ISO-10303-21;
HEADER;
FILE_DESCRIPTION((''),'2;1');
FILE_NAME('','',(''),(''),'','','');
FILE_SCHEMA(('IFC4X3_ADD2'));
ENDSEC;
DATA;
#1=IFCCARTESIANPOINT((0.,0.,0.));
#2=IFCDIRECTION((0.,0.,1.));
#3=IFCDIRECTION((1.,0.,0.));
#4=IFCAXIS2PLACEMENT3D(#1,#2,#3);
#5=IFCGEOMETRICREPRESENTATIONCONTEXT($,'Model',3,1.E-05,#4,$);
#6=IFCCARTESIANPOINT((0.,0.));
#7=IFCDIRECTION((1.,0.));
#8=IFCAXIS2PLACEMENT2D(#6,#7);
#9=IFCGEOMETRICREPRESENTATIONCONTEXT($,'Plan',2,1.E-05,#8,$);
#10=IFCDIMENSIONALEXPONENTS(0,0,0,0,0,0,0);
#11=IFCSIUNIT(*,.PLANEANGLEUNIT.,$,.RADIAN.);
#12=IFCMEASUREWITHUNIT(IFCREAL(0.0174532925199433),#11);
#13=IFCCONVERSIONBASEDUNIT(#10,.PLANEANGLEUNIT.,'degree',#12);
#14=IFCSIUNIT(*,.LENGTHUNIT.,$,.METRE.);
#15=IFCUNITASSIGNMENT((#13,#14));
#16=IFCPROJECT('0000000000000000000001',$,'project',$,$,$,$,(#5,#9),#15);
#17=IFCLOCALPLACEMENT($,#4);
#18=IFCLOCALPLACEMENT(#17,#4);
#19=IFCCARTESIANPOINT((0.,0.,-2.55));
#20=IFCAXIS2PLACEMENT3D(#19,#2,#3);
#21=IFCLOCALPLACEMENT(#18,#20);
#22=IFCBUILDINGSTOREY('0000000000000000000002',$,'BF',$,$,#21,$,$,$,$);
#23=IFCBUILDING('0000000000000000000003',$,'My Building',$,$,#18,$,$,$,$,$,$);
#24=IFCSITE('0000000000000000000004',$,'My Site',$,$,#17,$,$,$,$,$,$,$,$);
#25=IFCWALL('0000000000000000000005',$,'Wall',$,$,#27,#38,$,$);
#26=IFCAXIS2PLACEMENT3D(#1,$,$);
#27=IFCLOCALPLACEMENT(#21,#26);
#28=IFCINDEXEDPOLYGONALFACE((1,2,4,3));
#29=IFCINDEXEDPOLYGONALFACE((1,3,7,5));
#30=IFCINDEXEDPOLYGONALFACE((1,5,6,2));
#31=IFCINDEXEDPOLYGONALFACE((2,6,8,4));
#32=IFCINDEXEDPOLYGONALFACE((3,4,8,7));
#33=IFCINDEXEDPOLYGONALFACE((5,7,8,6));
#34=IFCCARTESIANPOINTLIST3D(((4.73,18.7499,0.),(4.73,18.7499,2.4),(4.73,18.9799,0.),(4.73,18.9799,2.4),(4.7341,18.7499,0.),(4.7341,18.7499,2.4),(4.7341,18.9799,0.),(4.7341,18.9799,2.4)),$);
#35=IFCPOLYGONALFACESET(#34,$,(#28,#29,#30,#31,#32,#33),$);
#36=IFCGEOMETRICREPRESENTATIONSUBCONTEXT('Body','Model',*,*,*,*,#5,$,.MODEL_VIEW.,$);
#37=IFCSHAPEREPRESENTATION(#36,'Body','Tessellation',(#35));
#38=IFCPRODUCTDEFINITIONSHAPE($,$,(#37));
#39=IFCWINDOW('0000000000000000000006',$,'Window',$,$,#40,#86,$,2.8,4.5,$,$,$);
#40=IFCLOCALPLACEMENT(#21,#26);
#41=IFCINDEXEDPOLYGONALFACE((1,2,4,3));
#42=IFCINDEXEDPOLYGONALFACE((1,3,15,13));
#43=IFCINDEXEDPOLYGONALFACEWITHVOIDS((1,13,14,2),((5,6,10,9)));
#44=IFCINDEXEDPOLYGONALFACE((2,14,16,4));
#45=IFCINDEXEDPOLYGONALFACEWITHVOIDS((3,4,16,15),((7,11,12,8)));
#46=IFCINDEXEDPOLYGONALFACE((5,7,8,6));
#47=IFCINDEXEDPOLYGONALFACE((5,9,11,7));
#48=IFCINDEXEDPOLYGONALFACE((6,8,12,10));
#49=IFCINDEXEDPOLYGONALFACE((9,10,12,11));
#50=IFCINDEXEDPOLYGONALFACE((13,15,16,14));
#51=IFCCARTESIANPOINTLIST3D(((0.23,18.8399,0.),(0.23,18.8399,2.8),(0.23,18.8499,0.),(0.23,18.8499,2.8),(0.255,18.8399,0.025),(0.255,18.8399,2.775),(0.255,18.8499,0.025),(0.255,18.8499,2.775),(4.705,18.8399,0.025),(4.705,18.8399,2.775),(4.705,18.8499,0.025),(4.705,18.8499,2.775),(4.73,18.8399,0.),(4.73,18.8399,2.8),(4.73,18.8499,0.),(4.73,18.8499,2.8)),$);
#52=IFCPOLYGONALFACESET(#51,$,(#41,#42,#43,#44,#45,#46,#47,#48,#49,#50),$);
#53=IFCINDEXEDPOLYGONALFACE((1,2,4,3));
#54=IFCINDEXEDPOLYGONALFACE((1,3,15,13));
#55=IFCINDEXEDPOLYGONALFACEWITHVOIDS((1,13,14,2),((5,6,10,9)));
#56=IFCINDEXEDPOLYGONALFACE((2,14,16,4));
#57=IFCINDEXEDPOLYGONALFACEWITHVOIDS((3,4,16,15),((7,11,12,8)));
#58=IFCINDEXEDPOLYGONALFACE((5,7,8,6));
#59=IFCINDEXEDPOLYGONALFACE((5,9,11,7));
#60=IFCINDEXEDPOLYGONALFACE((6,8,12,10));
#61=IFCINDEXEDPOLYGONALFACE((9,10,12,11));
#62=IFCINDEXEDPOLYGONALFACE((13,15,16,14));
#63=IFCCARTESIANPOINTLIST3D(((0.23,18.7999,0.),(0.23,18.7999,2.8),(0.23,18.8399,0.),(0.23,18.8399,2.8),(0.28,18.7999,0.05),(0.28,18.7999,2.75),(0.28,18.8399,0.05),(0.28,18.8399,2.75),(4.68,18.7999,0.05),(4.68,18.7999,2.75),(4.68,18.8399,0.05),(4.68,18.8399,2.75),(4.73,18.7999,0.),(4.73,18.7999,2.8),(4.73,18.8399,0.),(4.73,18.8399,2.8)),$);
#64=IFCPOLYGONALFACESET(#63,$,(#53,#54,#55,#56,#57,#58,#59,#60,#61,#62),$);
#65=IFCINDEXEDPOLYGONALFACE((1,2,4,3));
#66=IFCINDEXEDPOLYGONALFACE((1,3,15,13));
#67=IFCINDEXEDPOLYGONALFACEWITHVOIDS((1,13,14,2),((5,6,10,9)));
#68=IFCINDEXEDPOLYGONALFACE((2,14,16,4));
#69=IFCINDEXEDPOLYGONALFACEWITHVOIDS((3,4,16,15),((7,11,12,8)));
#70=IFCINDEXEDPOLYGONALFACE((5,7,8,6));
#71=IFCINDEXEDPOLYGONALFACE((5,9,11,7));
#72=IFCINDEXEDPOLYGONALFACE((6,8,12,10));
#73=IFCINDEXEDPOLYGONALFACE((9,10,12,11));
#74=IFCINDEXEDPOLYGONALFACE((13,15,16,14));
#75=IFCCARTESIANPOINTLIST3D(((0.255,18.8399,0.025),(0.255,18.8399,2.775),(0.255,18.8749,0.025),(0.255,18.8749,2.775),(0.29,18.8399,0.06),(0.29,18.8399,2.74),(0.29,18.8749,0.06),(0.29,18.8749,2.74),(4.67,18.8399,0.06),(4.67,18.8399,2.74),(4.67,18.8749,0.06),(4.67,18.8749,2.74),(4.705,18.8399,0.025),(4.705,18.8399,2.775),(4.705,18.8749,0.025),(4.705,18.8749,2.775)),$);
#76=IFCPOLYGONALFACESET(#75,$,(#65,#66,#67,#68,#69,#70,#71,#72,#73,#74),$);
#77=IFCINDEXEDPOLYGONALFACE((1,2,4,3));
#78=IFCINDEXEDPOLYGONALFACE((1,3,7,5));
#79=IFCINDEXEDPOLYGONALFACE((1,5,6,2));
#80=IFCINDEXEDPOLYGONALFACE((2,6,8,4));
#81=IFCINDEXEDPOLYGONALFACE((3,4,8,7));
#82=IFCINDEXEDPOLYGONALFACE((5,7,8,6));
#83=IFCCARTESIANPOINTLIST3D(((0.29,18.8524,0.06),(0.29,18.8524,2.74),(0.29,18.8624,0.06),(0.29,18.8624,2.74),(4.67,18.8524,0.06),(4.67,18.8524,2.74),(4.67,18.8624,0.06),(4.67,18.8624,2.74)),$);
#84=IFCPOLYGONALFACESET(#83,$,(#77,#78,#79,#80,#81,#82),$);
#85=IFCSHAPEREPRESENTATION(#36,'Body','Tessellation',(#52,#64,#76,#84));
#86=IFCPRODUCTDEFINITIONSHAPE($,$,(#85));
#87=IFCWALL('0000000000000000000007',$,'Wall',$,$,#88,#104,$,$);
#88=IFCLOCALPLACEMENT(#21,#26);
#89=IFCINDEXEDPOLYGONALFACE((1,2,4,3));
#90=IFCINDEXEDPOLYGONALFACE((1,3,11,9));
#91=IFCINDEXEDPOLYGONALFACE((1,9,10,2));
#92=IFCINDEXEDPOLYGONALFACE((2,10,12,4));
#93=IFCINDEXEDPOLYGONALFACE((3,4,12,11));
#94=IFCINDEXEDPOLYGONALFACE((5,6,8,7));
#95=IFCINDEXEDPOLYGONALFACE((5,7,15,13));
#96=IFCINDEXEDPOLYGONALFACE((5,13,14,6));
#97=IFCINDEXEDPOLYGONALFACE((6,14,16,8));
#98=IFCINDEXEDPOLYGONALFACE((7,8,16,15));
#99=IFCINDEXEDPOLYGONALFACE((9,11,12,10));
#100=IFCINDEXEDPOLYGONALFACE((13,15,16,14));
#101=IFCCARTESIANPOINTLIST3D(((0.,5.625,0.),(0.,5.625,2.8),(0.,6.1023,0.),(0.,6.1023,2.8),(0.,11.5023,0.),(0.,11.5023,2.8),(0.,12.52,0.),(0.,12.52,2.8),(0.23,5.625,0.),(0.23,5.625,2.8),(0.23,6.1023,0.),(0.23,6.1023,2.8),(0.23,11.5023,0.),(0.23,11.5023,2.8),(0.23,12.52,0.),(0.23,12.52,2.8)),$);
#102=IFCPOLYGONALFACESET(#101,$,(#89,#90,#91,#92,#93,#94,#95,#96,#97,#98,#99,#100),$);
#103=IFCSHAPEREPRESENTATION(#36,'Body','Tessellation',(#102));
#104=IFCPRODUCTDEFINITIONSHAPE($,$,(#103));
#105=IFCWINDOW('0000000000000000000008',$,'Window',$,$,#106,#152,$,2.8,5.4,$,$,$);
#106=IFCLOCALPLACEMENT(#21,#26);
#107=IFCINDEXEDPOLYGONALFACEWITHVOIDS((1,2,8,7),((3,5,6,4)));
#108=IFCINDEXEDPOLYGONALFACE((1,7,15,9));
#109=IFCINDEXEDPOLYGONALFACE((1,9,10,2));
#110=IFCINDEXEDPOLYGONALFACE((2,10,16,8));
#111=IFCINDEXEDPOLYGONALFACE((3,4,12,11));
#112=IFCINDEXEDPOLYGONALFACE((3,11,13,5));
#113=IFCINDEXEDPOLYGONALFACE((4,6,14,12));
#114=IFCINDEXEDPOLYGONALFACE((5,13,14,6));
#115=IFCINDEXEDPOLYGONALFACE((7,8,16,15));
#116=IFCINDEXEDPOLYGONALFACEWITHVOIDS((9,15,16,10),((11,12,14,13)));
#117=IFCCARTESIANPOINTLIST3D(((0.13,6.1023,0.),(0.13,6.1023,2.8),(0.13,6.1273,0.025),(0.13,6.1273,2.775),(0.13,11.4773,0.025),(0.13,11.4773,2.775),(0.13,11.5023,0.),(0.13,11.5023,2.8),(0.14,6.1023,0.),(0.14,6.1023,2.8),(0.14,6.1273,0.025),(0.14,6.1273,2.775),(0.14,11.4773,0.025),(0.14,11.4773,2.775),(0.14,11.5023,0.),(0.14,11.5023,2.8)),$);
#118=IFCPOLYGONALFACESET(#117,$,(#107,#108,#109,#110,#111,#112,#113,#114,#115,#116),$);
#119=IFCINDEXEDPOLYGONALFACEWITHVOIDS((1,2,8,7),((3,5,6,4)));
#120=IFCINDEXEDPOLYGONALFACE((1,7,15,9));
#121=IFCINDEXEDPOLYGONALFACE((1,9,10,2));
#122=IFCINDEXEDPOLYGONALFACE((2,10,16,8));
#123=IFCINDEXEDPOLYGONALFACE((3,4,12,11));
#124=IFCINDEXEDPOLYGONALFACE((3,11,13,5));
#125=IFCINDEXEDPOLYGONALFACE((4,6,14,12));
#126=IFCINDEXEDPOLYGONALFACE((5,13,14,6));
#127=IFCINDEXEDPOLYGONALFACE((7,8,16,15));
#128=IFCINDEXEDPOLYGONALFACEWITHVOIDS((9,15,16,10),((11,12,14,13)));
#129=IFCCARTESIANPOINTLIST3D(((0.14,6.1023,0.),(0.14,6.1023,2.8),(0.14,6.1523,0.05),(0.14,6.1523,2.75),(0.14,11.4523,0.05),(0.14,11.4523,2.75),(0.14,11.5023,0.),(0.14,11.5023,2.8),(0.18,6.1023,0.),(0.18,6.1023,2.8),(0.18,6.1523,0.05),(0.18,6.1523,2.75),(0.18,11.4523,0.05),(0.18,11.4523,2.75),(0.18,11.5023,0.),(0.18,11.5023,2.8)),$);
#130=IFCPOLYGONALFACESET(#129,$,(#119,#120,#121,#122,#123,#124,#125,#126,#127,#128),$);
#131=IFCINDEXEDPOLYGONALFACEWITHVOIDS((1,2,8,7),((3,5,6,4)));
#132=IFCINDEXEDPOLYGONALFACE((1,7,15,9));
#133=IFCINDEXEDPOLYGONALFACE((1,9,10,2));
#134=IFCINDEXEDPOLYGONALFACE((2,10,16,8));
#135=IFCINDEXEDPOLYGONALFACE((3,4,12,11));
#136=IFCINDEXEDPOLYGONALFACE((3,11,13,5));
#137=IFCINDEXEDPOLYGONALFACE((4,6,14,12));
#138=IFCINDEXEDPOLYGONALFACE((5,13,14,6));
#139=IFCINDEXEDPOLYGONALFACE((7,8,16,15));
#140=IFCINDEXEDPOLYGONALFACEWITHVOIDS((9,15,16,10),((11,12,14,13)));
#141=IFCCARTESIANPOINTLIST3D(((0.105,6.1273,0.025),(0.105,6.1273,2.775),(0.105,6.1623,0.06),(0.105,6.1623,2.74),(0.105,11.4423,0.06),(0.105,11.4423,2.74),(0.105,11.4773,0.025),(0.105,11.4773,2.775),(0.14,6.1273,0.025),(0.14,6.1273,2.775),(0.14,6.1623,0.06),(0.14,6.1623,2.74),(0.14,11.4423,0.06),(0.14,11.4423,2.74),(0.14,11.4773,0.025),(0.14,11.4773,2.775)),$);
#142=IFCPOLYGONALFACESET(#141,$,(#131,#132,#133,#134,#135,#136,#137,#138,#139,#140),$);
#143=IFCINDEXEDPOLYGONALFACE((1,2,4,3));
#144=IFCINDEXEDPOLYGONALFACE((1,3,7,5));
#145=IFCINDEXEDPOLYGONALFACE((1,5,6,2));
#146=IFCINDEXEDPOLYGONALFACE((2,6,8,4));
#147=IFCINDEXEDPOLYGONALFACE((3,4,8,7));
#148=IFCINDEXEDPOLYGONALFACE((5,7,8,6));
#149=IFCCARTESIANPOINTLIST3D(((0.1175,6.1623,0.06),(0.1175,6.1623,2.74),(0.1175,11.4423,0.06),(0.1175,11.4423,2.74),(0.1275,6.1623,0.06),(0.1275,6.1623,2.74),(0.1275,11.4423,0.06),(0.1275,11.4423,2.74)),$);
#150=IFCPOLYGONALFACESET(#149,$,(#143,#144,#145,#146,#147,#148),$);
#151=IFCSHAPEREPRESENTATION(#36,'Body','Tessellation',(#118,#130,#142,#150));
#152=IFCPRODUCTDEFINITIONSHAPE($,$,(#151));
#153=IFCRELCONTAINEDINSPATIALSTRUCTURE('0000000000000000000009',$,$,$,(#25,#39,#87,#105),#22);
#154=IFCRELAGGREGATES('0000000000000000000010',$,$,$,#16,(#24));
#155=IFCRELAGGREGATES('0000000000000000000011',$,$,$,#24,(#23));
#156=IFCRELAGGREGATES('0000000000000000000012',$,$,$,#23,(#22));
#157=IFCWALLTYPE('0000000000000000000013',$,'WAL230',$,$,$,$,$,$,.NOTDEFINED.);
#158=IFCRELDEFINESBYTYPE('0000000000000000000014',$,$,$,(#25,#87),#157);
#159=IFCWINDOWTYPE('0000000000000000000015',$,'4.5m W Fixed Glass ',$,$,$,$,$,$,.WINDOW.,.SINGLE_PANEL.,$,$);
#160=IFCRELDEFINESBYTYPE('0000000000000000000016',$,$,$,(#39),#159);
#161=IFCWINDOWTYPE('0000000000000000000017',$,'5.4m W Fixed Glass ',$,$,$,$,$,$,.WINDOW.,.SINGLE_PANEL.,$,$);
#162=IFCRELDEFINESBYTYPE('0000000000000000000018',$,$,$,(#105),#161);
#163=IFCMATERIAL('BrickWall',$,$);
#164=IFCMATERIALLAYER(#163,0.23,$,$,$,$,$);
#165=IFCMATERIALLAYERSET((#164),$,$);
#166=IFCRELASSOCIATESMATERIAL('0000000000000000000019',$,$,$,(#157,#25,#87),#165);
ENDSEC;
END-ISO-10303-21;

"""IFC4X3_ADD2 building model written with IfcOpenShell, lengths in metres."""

from ifc_helpers import new_model, entity, si_unit, converted_unit, frame, origin_with_axes, origin_2d_with_axis, place, context, subcontext, project, spatial, line, indexed_curve, outline, extrude, shape, source, transform, mapped, material, layer, layer_set, layer_usage, type_object, type_shapes, element, fill, save


model = new_model("IFC4X3_ADD2")

# Units and contexts
model_context = context("Model", 3, precision=1e-05, world=origin_with_axes())
plan_context = context("Plan", 2, precision=1e-05, world=origin_2d_with_axis())
body_context_1 = subcontext(model_context, "Body", "Model", "MODEL_VIEW")
body_context_2 = subcontext(plan_context, "Body", "Plan", "PLAN_VIEW")
ifc_project = project(units=[converted_unit("PLANEANGLEUNIT", "degree", entity("IfcReal", 0.0174532925199433), si_unit("PLANEANGLEUNIT", "RADIAN"), dimensions=[0, 0, 0, 0, 0, 0, 0]), si_unit("LENGTHUNIT", "METRE")], contexts=[model_context, plan_context])

# Site, building, storey
site_placement = place(None, origin_with_axes())
site = spatial("IfcSite", under=ifc_project, at=site_placement, Name="My Site")
building_placement = place(site_placement, origin_with_axes())
building = spatial("IfcBuilding", under=site, at=building_placement, Name="My Building")
storey_placement = place(building_placement, frame((0.0, 0.0, -2.55), z_axis=(0.0, 0.0, 1.0), x_axis=(1.0, 0.0, 0.0)))
storey = spatial("IfcBuildingStorey", under=building, at=storey_placement, Name="BF")

# Shared definitions
ifc_material_1 = material(Name="BrickWall")

# Walls, openings, windows
ifc_layer_1 = layer(ifc_material_1, 0.23)
ifc_layer_set_1 = layer_set([ifc_layer_1])
ifc_layer_usage_1 = layer_usage(ifc_layer_set_1, "AXIS2", "POSITIVE", 0.0)
wall_type_1 = type_object("IfcWallType", Name="WAL230", PredefinedType="NOTDEFINED", material=ifc_layer_set_1)
wall_1_placement = place(storey_placement, frame((0.23, 18.7499, 0.0), z_axis=(0.0, 0.0, 1.0), x_axis=(1.0, 0.0, 0.0)))
wall_1 = element("IfcWall", 1, at=wall_1_placement, inside=storey, type_object=wall_type_1, material=ifc_layer_usage_1, Name="Wall", context=body_context_1, shape_type="SweptSolid", body=[
    extrude(outline(indexed_curve([(0.0, 0.0), (0.0, 0.23), (4.5041, 0.23), (4.5041, 0.0), (0.0, 0.0)], self_intersect=False)), origin_with_axes(), (0.0, 0.0, 1.0), 2.4),
])
shared_shape_1 = source(origin_with_axes(), body_context_1, "Body", "SweptSolid", [
    extrude(outline(indexed_curve([(0.0, 0.0), (4.5, 0.0), (4.5, 2.8), (0.0, 2.8)], segments=[line(1, 2, 3, 4, 1)])), frame((0.0, -0.6, 0.0), z_axis=(0.0, -1.0, 0.0), x_axis=(1.0, 0.0, 0.0)), (0.0, 0.0, -1.0), 1.2),
])
opening_1_placement = place(wall_1_placement, frame((0.0, 0.0, 0.0), z_axis=(0.0, 0.0, 1.0), x_axis=(1.0, 0.0, 0.0)))
opening_1 = element("IfcOpeningElement", 2, at=opening_1_placement, cuts=wall_1, PredefinedType="OPENING", context=body_context_1, shape_type="MappedRepresentation", body=[
    mapped(shared_shape_1, transform((0.0, 0.0, 0.0), x_axis=(1.0, 0.0, 0.0), y_axis=(0.0, 1.0, 0.0), z_axis=(0.0, 0.0, 1.0), scale=1.0)),
])
window_type_1 = type_object("IfcWindowType", Name="4.5m W Fixed Glass ", PartitioningType="SINGLE_PANEL", PredefinedType="WINDOW")
shared_shape_2 = source(origin_with_axes(), body_context_1, "Body", "SweptSolid", [
    extrude(outline(indexed_curve([(0.0, 0.0), (4.5, 0.0), (4.5, 2.8), (0.0, 2.8)], segments=[line(1, 2, 3, 4, 1)]), holes=[indexed_curve([(0.025, 0.025), (4.475, 0.025), (4.475, 2.775), (0.025, 2.775)], segments=[line(1, 2, 3, 4, 1)])]), frame((0.0, 0.09, 0.0), z_axis=(0.0, -1.0, 0.0), x_axis=(1.0, 0.0, 0.0)), (0.0, 0.0, -1.0), 0.01),
    extrude(outline(indexed_curve([(0.0, 0.0), (4.5, 0.0), (4.5, 2.8), (0.0, 2.8)], segments=[line(1, 2, 3, 4, 1)]), holes=[indexed_curve([(0.05, 0.05), (4.45, 0.05), (4.45, 2.75), (0.05, 2.75)], segments=[line(1, 2, 3, 4, 1)])]), frame((0.0, 0.05, 0.0), z_axis=(0.0, -1.0, 0.0), x_axis=(1.0, 0.0, 0.0)), (0.0, 0.0, -1.0), 0.04),
    extrude(outline(indexed_curve([(0.0, 0.0), (4.45, 0.0), (4.45, 2.75), (0.0, 2.75)], segments=[line(1, 2, 3, 4, 1)]), holes=[indexed_curve([(0.035, 0.035), (4.415, 0.035), (4.415, 2.715), (0.035, 2.715)], segments=[line(1, 2, 3, 4, 1)])]), frame((0.025, 0.09, 0.025), z_axis=(0.0, -1.0, 0.0), x_axis=(1.0, 0.0, 0.0)), (0.0, 0.0, -1.0), 0.035),
    extrude(outline(indexed_curve([(0.035, 0.035), (4.415, 0.035), (4.415, 2.715), (0.035, 2.715)], segments=[line(1, 2, 3, 4, 1)])), frame((0.025, 0.1025, 0.025), z_axis=(0.0, -1.0, 0.0), x_axis=(1.0, 0.0, 0.0)), (0.0, 0.0, -1.0), 0.01),
])
shared_shape_3 = source(origin_with_axes(), body_context_2, "Body", "Curve2D", [
    entity("IfcIndexedPolyCurve", entity("IfcCartesianPointList2D", [[0.05, 0.05], [4.45, 0.05]])),
    entity("IfcIndexedPolyCurve", entity("IfcCartesianPointList2D", [[0.0, 0.1], [0.025, 0.1], [0.025, 0.09], [0.05, 0.09], [0.05, 0.05], [0.0, 0.05]]), [entity("IfcLineIndex", [1, 2, 3, 4, 5, 6, 1])]),
    entity("IfcIndexedPolyCurve", entity("IfcCartesianPointList2D", [[4.5, 0.1], [4.475, 0.1], [4.475, 0.09], [4.45, 0.09], [4.45, 0.05], [4.5, 0.05]]), [entity("IfcLineIndex", [1, 2, 3, 4, 5, 6, 1])]),
    entity("IfcIndexedPolyCurve", entity("IfcCartesianPointList2D", [[0.025, 0.09], [0.06, 0.09], [0.06, 0.125], [0.025, 0.125]]), [entity("IfcLineIndex", [1, 2, 3, 4, 1])]),
    entity("IfcIndexedPolyCurve", entity("IfcCartesianPointList2D", [[4.475, 0.09], [4.44, 0.09], [4.44, 0.125], [4.475, 0.125]]), [entity("IfcLineIndex", [1, 2, 3, 4, 1])]),
    entity("IfcIndexedPolyCurve", entity("IfcCartesianPointList2D", [[0.06, 0.09], [4.44, 0.09]])),
    entity("IfcIndexedPolyCurve", entity("IfcCartesianPointList2D", [[0.06, 0.125], [4.44, 0.125]])),
    entity("IfcIndexedPolyCurve", entity("IfcCartesianPointList2D", [[0.06, 0.1075], [4.44, 0.1075]])),
])
type_shapes(window_type_1, [shared_shape_2, shared_shape_3])
window_1_placement = place(opening_1_placement, origin_with_axes())
window_1 = element("IfcWindow", 3, at=window_1_placement, inside=storey, type_object=window_type_1, Name="Window", OverallHeight=2.8, OverallWidth=4.5, shapes=[
    shape(body_context_1, "Body", "MappedRepresentation", [mapped(shared_shape_2, transform((0.0, 0.0, 0.0), x_axis=(1.0, 0.0, 0.0), y_axis=(0.0, 1.0, 0.0), z_axis=(0.0, 0.0, 1.0), scale=1.0))]),
    shape(body_context_2, "Body", "MappedRepresentation", [mapped(shared_shape_3, transform((0.0, 0.0, 0.0), x_axis=(1.0, 0.0, 0.0), y_axis=(0.0, 1.0, 0.0), z_axis=(0.0, 0.0, 1.0), scale=1.0))]),
])
fill(opening_1, window_1)
ifc_layer_usage_2 = layer_usage(ifc_layer_set_1, "AXIS2", "POSITIVE", 0.0)
wall_2_placement = place(storey_placement, frame((0.23, 5.625, 0.0), z_axis=(0.0, 0.0, 1.0), x_axis=(0.0, 1.0, 0.0)))
wall_2 = element("IfcWall", 4, at=wall_2_placement, inside=storey, type_object=wall_type_1, material=ifc_layer_usage_2, Name="Wall", context=body_context_1, shape_type="SweptSolid", body=[
    extrude(outline(indexed_curve([(0.0, 0.0), (0.0, 0.23), (6.895, 0.23), (6.895, 0.0), (0.0, 0.0)], self_intersect=False)), origin_with_axes(), (0.0, 0.0, 1.0), 2.8),
])
shared_shape_4 = source(origin_with_axes(), body_context_1, "Body", "SweptSolid", [
    extrude(outline(indexed_curve([(0.0, 0.0), (5.4, 0.0), (5.4, 2.8), (0.0, 2.8)], segments=[line(1, 2, 3, 4, 1)])), frame((0.0, -0.6, 0.0), z_axis=(0.0, -1.0, 0.0), x_axis=(1.0, 0.0, 0.0)), (0.0, 0.0, -1.0), 1.2),
])
opening_2_placement = place(wall_2_placement, frame((0.4773, 0.0, 0.0), z_axis=(0.0, 0.0, 1.0), x_axis=(1.0, 0.0, 0.0)))
opening_2 = element("IfcOpeningElement", 5, at=opening_2_placement, cuts=wall_2, PredefinedType="OPENING", context=body_context_1, shape_type="MappedRepresentation", body=[
    mapped(shared_shape_4, transform((0.0, 0.0, 0.0), x_axis=(1.0, 0.0, 0.0), y_axis=(0.0, 1.0, 0.0), z_axis=(0.0, 0.0, 1.0), scale=1.0)),
])
window_type_2 = type_object("IfcWindowType", Name="5.4m W Fixed Glass ", PartitioningType="SINGLE_PANEL", PredefinedType="WINDOW")
shared_shape_5 = source(origin_with_axes(), body_context_1, "Body", "SweptSolid", [
    extrude(outline(indexed_curve([(0.0, 0.0), (5.4, 0.0), (5.4, 2.8), (0.0, 2.8)], segments=[line(1, 2, 3, 4, 1)]), holes=[indexed_curve([(0.025, 0.025), (5.375, 0.025), (5.375, 2.775), (0.025, 2.775)], segments=[line(1, 2, 3, 4, 1)])]), frame((0.0, 0.09, 0.0), z_axis=(0.0, -1.0, 0.0), x_axis=(1.0, 0.0, 0.0)), (0.0, 0.0, -1.0), 0.01),
    extrude(outline(indexed_curve([(0.0, 0.0), (5.4, 0.0), (5.4, 2.8), (0.0, 2.8)], segments=[line(1, 2, 3, 4, 1)]), holes=[indexed_curve([(0.05, 0.05), (5.35, 0.05), (5.35, 2.75), (0.05, 2.75)], segments=[line(1, 2, 3, 4, 1)])]), frame((0.0, 0.05, 0.0), z_axis=(0.0, -1.0, 0.0), x_axis=(1.0, 0.0, 0.0)), (0.0, 0.0, -1.0), 0.04),
    extrude(outline(indexed_curve([(0.0, 0.0), (5.35, 0.0), (5.35, 2.75), (0.0, 2.75)], segments=[line(1, 2, 3, 4, 1)]), holes=[indexed_curve([(0.035, 0.035), (5.315, 0.035), (5.315, 2.715), (0.035, 2.715)], segments=[line(1, 2, 3, 4, 1)])]), frame((0.025, 0.09, 0.025), z_axis=(0.0, -1.0, 0.0), x_axis=(1.0, 0.0, 0.0)), (0.0, 0.0, -1.0), 0.035),
    extrude(outline(indexed_curve([(0.035, 0.035), (5.315, 0.035), (5.315, 2.715), (0.035, 2.715)], segments=[line(1, 2, 3, 4, 1)])), frame((0.025, 0.1025, 0.025), z_axis=(0.0, -1.0, 0.0), x_axis=(1.0, 0.0, 0.0)), (0.0, 0.0, -1.0), 0.01),
])
shared_shape_6 = source(origin_with_axes(), body_context_2, "Body", "Curve2D", [
    entity("IfcIndexedPolyCurve", entity("IfcCartesianPointList2D", [[0.05, 0.05], [5.35, 0.05]])),
    entity("IfcIndexedPolyCurve", entity("IfcCartesianPointList2D", [[0.0, 0.1], [0.025, 0.1], [0.025, 0.09], [0.05, 0.09], [0.05, 0.05], [0.0, 0.05]]), [entity("IfcLineIndex", [1, 2, 3, 4, 5, 6, 1])]),
    entity("IfcIndexedPolyCurve", entity("IfcCartesianPointList2D", [[5.4, 0.1], [5.375, 0.1], [5.375, 0.09], [5.35, 0.09], [5.35, 0.05], [5.4, 0.05]]), [entity("IfcLineIndex", [1, 2, 3, 4, 5, 6, 1])]),
    entity("IfcIndexedPolyCurve", entity("IfcCartesianPointList2D", [[0.025, 0.09], [0.06, 0.09], [0.06, 0.125], [0.025, 0.125]]), [entity("IfcLineIndex", [1, 2, 3, 4, 1])]),
    entity("IfcIndexedPolyCurve", entity("IfcCartesianPointList2D", [[5.375, 0.09], [5.34, 0.09], [5.34, 0.125], [5.375, 0.125]]), [entity("IfcLineIndex", [1, 2, 3, 4, 1])]),
    entity("IfcIndexedPolyCurve", entity("IfcCartesianPointList2D", [[0.06, 0.09], [5.34, 0.09]])),
    entity("IfcIndexedPolyCurve", entity("IfcCartesianPointList2D", [[0.06, 0.125], [5.34, 0.125]])),
    entity("IfcIndexedPolyCurve", entity("IfcCartesianPointList2D", [[0.06, 0.1075], [5.34, 0.1075]])),
])
type_shapes(window_type_2, [shared_shape_5, shared_shape_6])
window_2_placement = place(opening_2_placement, frame((0.0, 0.0, 0.0), z_axis=(0.0, 0.0, 1.0), x_axis=(1.0, 0.0, 0.0)))
window_2 = element("IfcWindow", 6, at=window_2_placement, inside=storey, type_object=window_type_2, Name="Window", OverallHeight=2.8, OverallWidth=5.4, shapes=[
    shape(body_context_1, "Body", "MappedRepresentation", [mapped(shared_shape_5, transform((0.0, 0.0, 0.0), x_axis=(1.0, 0.0, 0.0), y_axis=(0.0, 1.0, 0.0), z_axis=(0.0, 0.0, 1.0), scale=1.0))]),
    shape(body_context_2, "Body", "MappedRepresentation", [mapped(shared_shape_6, transform((0.0, 0.0, 0.0), x_axis=(1.0, 0.0, 0.0), y_axis=(0.0, 1.0, 0.0), z_axis=(0.0, 0.0, 1.0), scale=1.0))]),
])
fill(opening_2, window_2)

save(model, "model.ifc")
